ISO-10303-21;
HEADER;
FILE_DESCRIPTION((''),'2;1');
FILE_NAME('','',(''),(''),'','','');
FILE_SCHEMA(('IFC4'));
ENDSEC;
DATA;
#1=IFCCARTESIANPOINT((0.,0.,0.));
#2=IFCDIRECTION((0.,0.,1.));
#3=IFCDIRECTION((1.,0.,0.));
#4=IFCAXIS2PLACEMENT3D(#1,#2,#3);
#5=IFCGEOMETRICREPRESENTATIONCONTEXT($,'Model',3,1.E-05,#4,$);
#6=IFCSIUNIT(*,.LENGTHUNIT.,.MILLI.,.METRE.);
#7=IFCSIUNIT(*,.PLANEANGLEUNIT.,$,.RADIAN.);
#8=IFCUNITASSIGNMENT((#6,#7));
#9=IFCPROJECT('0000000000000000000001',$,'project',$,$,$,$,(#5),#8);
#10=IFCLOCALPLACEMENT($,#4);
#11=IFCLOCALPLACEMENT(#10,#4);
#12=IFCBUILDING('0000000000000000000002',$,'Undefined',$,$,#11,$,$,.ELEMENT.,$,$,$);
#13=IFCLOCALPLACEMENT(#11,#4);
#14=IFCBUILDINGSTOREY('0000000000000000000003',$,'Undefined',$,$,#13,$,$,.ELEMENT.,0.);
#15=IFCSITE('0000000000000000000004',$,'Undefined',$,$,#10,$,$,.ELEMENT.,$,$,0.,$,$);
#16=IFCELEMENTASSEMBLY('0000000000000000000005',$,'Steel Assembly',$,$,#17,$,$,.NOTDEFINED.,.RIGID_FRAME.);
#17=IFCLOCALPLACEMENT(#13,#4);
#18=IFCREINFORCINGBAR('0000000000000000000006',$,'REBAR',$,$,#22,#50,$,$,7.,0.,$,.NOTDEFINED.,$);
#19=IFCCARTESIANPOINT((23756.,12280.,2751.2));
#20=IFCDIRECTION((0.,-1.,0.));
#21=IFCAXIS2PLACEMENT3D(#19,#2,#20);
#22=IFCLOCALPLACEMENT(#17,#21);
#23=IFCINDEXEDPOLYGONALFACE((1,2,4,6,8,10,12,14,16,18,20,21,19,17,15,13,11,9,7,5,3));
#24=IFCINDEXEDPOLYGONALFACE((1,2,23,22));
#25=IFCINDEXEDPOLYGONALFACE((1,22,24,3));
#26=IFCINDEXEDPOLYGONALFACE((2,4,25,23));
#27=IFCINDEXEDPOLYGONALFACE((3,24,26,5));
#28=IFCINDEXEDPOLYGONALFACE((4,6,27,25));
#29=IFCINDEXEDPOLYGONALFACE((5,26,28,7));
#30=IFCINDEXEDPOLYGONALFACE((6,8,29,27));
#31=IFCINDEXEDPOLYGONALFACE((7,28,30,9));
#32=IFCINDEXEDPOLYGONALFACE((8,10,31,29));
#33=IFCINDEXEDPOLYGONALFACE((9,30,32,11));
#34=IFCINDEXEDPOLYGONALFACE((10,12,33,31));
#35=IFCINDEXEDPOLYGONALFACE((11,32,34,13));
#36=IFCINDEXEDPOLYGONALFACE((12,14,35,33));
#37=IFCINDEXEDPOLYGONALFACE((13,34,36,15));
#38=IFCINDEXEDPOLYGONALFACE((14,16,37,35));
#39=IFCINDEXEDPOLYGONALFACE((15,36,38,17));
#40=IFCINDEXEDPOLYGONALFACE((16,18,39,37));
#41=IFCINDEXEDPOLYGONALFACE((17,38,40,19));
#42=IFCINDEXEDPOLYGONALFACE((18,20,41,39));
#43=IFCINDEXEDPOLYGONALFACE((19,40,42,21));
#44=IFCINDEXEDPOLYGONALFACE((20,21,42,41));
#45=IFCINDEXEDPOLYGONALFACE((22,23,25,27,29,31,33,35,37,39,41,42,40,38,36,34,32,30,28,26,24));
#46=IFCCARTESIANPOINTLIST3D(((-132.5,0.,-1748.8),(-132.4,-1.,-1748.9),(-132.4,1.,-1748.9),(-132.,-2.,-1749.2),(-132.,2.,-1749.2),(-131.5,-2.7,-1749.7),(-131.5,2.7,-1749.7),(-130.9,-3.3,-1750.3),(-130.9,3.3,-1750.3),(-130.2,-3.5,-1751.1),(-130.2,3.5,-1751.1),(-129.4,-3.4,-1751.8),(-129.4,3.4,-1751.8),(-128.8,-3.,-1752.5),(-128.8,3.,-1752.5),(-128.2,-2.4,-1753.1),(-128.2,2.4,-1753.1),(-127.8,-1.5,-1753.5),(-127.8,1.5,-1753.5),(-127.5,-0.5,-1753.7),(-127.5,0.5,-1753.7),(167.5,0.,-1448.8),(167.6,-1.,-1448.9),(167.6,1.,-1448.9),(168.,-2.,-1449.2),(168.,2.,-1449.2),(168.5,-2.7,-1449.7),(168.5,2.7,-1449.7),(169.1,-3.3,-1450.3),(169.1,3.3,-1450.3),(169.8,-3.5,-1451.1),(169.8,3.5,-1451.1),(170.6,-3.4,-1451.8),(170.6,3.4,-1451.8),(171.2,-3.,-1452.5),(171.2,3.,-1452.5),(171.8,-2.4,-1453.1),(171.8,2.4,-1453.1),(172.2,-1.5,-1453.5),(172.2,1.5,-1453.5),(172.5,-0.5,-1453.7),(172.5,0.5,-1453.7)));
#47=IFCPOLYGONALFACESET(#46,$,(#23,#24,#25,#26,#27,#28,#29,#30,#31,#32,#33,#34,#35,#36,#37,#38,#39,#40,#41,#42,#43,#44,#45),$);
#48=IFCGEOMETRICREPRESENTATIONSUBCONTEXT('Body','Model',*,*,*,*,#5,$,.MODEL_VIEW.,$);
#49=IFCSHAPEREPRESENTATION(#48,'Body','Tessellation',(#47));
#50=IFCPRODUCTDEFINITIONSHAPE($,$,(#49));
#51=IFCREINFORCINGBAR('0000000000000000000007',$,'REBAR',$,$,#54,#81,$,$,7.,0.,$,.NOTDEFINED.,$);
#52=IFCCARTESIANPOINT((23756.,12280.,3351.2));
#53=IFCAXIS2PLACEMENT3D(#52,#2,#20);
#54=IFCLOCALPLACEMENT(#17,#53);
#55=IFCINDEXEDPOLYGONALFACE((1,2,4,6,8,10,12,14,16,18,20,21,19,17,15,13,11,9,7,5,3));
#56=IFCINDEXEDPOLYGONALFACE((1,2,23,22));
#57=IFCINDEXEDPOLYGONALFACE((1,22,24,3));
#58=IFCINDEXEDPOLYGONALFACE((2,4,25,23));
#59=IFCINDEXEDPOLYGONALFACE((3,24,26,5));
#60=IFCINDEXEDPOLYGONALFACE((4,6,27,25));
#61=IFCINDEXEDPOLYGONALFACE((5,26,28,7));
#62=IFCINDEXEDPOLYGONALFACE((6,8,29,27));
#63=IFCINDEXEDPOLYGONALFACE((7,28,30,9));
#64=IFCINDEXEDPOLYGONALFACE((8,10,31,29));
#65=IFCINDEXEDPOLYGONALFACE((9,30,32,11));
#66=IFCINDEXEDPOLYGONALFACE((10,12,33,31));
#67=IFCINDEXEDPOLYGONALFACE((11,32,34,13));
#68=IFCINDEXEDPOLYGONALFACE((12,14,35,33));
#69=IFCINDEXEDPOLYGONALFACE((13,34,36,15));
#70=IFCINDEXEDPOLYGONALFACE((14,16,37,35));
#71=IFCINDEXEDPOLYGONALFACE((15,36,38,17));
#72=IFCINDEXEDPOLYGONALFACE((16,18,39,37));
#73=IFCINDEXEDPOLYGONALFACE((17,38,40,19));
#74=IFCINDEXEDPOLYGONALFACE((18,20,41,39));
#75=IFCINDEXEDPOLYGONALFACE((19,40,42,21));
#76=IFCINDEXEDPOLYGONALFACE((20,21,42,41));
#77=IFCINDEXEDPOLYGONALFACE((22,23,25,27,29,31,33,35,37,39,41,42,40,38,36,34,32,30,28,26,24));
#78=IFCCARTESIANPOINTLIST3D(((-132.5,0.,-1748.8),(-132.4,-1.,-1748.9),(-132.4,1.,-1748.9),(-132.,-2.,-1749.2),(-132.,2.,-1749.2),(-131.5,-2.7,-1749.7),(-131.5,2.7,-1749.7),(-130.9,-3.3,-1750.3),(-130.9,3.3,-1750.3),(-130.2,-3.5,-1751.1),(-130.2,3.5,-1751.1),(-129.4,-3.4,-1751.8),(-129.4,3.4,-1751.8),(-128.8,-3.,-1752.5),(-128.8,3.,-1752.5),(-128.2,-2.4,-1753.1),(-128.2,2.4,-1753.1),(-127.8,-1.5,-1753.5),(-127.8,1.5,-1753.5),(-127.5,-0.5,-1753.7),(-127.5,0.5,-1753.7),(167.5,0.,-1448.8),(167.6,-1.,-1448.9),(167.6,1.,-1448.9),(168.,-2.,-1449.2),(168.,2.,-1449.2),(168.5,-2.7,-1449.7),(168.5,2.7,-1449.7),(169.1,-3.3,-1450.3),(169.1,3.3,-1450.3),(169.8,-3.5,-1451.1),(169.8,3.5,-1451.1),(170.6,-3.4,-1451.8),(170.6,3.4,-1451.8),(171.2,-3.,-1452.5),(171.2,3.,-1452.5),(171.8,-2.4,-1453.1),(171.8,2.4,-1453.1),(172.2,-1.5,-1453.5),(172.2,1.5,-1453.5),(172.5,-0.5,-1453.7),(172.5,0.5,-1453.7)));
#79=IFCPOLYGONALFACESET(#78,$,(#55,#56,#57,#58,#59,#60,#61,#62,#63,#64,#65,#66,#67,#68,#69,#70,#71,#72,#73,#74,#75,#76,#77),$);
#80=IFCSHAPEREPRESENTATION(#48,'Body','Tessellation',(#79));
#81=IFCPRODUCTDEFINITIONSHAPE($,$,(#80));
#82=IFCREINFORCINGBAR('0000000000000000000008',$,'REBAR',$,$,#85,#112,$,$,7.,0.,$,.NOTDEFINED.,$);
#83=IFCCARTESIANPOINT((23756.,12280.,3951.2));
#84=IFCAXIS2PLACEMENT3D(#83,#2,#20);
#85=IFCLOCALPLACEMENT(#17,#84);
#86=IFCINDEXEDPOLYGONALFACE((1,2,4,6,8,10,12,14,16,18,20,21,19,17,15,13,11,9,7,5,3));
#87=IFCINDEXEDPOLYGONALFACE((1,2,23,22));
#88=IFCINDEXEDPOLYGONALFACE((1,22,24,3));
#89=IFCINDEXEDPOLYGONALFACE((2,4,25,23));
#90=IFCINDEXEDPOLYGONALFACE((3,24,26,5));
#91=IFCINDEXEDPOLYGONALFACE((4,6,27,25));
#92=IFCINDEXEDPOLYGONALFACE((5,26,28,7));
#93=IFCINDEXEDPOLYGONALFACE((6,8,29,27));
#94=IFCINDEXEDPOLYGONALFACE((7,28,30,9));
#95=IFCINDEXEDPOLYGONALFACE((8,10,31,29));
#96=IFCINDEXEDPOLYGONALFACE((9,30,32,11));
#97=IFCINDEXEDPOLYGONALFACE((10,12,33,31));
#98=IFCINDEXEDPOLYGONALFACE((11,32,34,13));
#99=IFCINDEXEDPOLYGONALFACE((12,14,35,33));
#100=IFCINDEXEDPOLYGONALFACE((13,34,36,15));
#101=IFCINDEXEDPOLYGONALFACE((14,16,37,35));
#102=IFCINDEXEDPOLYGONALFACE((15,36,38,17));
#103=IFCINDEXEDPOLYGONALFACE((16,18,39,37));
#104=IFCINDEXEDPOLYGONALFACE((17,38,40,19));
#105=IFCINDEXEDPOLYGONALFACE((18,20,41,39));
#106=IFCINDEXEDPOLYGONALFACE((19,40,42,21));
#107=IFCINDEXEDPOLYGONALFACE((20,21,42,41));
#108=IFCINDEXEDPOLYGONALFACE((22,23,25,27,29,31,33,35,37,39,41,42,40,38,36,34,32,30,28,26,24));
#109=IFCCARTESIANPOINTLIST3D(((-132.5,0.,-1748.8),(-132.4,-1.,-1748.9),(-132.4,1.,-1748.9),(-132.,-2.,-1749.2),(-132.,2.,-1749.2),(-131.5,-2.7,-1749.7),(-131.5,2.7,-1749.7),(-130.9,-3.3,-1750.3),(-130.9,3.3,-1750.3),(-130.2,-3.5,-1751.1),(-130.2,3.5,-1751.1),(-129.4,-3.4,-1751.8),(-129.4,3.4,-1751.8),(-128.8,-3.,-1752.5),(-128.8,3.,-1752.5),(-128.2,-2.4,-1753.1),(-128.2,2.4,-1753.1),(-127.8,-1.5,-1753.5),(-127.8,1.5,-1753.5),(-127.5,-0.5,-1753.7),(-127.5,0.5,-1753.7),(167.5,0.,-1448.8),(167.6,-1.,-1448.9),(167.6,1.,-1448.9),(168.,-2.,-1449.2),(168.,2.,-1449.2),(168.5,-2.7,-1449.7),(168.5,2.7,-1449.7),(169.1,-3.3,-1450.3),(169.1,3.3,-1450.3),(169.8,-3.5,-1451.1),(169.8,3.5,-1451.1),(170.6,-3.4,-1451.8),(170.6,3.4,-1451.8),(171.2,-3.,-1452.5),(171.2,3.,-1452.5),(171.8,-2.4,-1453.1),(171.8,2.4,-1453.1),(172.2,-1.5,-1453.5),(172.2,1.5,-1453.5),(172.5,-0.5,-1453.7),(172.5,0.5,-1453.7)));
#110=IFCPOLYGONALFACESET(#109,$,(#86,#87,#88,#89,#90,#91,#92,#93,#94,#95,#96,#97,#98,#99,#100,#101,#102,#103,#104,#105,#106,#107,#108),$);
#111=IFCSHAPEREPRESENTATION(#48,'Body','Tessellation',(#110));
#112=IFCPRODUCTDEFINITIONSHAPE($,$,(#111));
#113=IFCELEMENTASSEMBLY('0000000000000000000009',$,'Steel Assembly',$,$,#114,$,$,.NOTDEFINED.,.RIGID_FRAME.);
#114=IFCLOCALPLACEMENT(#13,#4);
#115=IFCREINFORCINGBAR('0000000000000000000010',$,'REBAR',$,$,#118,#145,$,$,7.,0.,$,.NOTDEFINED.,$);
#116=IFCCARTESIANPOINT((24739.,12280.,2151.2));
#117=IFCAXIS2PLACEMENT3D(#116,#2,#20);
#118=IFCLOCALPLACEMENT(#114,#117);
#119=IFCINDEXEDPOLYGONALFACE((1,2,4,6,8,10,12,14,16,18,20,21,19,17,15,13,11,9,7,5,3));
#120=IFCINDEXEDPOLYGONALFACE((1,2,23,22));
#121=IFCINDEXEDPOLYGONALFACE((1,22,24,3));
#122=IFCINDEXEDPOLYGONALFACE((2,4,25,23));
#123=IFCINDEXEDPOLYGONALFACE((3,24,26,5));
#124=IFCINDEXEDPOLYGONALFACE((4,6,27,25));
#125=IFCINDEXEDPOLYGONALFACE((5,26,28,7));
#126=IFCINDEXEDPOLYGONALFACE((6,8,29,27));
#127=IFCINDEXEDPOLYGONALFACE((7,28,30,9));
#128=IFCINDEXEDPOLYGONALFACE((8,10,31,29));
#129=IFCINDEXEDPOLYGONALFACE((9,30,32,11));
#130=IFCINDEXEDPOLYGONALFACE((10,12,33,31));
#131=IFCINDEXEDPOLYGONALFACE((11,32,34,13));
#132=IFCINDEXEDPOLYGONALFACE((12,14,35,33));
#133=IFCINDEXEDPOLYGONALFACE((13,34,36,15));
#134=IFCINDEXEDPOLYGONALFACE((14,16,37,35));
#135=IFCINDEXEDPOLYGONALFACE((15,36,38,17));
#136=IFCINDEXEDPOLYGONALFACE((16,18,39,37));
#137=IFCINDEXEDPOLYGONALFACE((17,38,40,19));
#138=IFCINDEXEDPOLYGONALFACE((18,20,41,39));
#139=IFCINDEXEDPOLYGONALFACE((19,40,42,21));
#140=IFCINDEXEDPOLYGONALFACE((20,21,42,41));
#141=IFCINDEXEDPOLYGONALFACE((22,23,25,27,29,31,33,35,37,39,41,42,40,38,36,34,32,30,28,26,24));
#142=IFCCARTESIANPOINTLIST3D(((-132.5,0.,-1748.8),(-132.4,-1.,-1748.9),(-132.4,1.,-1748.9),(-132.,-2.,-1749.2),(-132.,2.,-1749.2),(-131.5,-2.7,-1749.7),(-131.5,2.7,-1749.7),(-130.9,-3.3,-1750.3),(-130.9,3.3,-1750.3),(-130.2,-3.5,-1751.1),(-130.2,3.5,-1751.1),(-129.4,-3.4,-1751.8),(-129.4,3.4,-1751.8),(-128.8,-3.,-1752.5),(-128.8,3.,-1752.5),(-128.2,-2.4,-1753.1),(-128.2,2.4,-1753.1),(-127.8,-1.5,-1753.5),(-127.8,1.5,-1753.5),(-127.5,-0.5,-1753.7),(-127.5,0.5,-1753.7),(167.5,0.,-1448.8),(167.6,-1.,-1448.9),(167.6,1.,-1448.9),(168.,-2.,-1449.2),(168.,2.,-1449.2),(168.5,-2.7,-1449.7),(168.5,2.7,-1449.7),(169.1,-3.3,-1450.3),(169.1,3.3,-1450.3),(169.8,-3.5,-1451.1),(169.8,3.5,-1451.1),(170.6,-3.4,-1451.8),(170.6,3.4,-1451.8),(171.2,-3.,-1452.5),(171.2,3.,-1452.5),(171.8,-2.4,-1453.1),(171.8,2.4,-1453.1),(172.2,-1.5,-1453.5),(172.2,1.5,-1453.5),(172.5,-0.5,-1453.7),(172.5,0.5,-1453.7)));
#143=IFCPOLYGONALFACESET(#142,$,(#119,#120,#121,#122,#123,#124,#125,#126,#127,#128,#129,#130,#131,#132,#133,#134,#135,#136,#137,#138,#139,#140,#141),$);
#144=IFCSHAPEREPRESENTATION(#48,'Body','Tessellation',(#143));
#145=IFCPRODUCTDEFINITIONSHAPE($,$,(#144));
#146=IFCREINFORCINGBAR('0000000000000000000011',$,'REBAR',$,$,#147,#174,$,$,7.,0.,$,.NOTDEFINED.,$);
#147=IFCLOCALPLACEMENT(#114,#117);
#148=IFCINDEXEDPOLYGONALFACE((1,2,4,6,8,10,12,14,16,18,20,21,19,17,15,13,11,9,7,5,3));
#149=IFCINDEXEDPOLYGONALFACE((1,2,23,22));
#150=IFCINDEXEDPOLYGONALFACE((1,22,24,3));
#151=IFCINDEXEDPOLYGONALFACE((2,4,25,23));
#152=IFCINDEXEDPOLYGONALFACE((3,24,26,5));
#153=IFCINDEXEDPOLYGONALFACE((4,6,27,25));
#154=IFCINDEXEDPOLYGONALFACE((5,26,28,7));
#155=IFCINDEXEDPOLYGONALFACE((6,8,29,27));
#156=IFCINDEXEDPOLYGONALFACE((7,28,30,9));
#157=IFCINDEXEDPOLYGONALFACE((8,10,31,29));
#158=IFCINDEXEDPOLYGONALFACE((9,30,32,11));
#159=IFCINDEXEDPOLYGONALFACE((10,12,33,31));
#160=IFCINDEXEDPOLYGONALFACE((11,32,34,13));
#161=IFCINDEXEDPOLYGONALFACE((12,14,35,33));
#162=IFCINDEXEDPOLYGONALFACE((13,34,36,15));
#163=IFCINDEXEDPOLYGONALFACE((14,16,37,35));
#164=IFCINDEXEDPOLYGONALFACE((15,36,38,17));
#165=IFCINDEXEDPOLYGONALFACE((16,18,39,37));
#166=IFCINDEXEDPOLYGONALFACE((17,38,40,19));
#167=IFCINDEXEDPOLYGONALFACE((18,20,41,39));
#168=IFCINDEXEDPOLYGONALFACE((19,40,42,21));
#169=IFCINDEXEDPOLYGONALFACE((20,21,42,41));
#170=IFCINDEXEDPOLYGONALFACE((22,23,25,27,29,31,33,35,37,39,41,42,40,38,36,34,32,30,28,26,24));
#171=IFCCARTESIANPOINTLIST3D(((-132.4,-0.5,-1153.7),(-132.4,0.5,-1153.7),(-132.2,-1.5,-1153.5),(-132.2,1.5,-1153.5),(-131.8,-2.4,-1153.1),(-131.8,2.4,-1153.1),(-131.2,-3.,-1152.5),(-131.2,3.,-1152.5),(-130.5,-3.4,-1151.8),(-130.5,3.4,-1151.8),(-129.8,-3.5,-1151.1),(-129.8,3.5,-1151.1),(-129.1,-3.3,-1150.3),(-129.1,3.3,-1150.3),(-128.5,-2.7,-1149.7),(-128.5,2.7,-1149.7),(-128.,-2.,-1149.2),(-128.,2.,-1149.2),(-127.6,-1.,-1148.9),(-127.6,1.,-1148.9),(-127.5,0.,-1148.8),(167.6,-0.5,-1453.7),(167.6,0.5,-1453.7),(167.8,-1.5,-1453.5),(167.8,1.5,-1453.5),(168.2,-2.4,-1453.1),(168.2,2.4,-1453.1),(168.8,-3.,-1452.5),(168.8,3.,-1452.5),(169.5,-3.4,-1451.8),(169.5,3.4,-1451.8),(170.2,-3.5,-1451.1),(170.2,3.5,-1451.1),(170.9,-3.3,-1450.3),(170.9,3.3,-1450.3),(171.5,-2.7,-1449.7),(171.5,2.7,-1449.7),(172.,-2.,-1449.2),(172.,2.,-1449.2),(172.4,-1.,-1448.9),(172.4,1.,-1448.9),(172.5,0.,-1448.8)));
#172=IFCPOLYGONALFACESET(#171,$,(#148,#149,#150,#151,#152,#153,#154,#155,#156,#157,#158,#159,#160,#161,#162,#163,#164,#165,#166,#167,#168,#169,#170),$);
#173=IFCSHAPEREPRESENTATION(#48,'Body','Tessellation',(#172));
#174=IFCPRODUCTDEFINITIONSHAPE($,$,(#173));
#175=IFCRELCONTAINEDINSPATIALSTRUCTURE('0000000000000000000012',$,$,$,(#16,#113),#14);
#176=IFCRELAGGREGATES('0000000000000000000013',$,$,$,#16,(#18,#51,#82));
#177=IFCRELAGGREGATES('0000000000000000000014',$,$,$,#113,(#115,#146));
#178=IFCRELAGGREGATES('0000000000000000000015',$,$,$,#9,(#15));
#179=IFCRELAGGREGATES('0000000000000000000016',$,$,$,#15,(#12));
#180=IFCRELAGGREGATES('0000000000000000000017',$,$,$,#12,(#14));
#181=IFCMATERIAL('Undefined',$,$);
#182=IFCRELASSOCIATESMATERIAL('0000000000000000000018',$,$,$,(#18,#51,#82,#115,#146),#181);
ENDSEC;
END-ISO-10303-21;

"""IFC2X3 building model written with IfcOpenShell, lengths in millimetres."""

from ifc_helpers import new_model, entity, si_unit, frame, origin_with_axes, place, context, subcontext, project, spatial, source, transform, mapped, material, element, aggregate, save


model = new_model("IFC2X3")

# Units and contexts
model_context = context("Model", 3, precision=1e-05, world=origin_with_axes())
body_context = subcontext(model_context, "Body", "Model", "MODEL_VIEW")
ifc_project = project(units=[si_unit("LENGTHUNIT", "METRE", prefix="MILLI"), si_unit("PLANEANGLEUNIT", "RADIAN")], contexts=[model_context])

# Site, building, storey
site_placement = place(None, origin_with_axes())
site = spatial("IfcSite", under=ifc_project, at=site_placement, Name="Undefined", CompositionType="ELEMENT", RefElevation=0.0)
building_placement = place(site_placement, origin_with_axes())
building = spatial("IfcBuilding", under=site, at=building_placement, Name="Undefined", CompositionType="ELEMENT")
storey_placement = place(building_placement, origin_with_axes())
storey = spatial("IfcBuildingStorey", under=building, at=storey_placement, Name="Undefined", CompositionType="ELEMENT", Elevation=0.0)

# Shared definitions
ifc_material_1 = material(Name="Undefined")

# Element assemblies, reinforcing bars
assembly_1_placement = place(storey_placement, origin_with_axes())
assembly_1 = element("IfcElementAssembly", 1, at=assembly_1_placement, inside=storey, Name="Steel Assembly", AssemblyPlace="NOTDEFINED", PredefinedType="RIGID_FRAME")
shared_shape_1 = source(origin_with_axes(), body_context, "Body", "AdvancedSweptSolid", [
    entity("IfcSweptDiskSolid", entity("IfcTrimmedCurve", entity("IfcLine", entity("IfcCartesianPoint", [0.0, 0.0, 0.0]), entity("IfcVector", entity("IfcDirection", [0.707107, 0.0, 0.707107]), 1.0)), [entity("IfcParameterValue", 0.0)], [entity("IfcParameterValue", 424.264069)], True, "PARAMETER"), 3.5, None, 0.0, 424.3),
])
reinforcing_bar_1_placement = place(assembly_1_placement, frame((23756.0, 12280.0, 2751.2), z_axis=(0.0, 0.0, 1.0), x_axis=(0.0, -1.0, 0.0)))
reinforcing_bar_1 = element("IfcReinforcingBar", 2, at=reinforcing_bar_1_placement, material=ifc_material_1, Name="REBAR", BarRole="NOTDEFINED", CrossSectionArea=0.0, NominalDiameter=7.0, context=body_context, shape_type="MappedRepresentation", body=[
    mapped(shared_shape_1, transform((-130.0, 0.0, -1751.2))),
])
shared_shape_2 = source(origin_with_axes(), body_context, "Body", "AdvancedSweptSolid", [
    entity("IfcSweptDiskSolid", entity("IfcTrimmedCurve", entity("IfcLine", entity("IfcCartesianPoint", [0.0, 0.0, 0.0]), entity("IfcVector", entity("IfcDirection", [0.707107, 0.0, 0.707107]), 1.0)), [entity("IfcParameterValue", 0.0)], [entity("IfcParameterValue", 424.264069)], True, "PARAMETER"), 3.5, None, 0.0, 424.3),
])
reinforcing_bar_2_placement = place(assembly_1_placement, frame((23756.0, 12280.0, 3351.2), z_axis=(0.0, 0.0, 1.0), x_axis=(0.0, -1.0, 0.0)))
reinforcing_bar_2 = element("IfcReinforcingBar", 3, at=reinforcing_bar_2_placement, material=ifc_material_1, Name="REBAR", BarRole="NOTDEFINED", CrossSectionArea=0.0, NominalDiameter=7.0, context=body_context, shape_type="MappedRepresentation", body=[
    mapped(shared_shape_2, transform((-130.0, 0.0, -1751.2))),
])
shared_shape_3 = source(origin_with_axes(), body_context, "Body", "AdvancedSweptSolid", [
    entity("IfcSweptDiskSolid", entity("IfcTrimmedCurve", entity("IfcLine", entity("IfcCartesianPoint", [0.0, 0.0, 0.0]), entity("IfcVector", entity("IfcDirection", [0.707107, 0.0, 0.707107]), 1.0)), [entity("IfcParameterValue", 0.0)], [entity("IfcParameterValue", 424.264069)], True, "PARAMETER"), 3.5, None, 0.0, 424.3),
])
reinforcing_bar_3_placement = place(assembly_1_placement, frame((23756.0, 12280.0, 3951.2), z_axis=(0.0, 0.0, 1.0), x_axis=(0.0, -1.0, 0.0)))
reinforcing_bar_3 = element("IfcReinforcingBar", 4, at=reinforcing_bar_3_placement, material=ifc_material_1, Name="REBAR", BarRole="NOTDEFINED", CrossSectionArea=0.0, NominalDiameter=7.0, context=body_context, shape_type="MappedRepresentation", body=[
    mapped(shared_shape_3, transform((-130.0, 0.0, -1751.2))),
])
aggregate(assembly_1, [reinforcing_bar_1, reinforcing_bar_2, reinforcing_bar_3])
assembly_2_placement = place(storey_placement, origin_with_axes())
assembly_2 = element("IfcElementAssembly", 5, at=assembly_2_placement, inside=storey, Name="Steel Assembly", AssemblyPlace="NOTDEFINED", PredefinedType="RIGID_FRAME")
shared_shape_4 = source(origin_with_axes(), body_context, "Body", "AdvancedSweptSolid", [
    entity("IfcSweptDiskSolid", entity("IfcTrimmedCurve", entity("IfcLine", entity("IfcCartesianPoint", [0.0, 0.0, 0.0]), entity("IfcVector", entity("IfcDirection", [0.707107, 0.0, 0.707107]), 1.0)), [entity("IfcParameterValue", 0.0)], [entity("IfcParameterValue", 424.264069)], True, "PARAMETER"), 3.5, None, 0.0, 424.3),
])
reinforcing_bar_4_placement = place(assembly_2_placement, frame((24739.0, 12280.0, 2151.2), z_axis=(0.0, 0.0, 1.0), x_axis=(0.0, -1.0, 0.0)))
reinforcing_bar_4 = element("IfcReinforcingBar", 6, at=reinforcing_bar_4_placement, material=ifc_material_1, Name="REBAR", BarRole="NOTDEFINED", CrossSectionArea=0.0, NominalDiameter=7.0, context=body_context, shape_type="MappedRepresentation", body=[
    mapped(shared_shape_4, transform((-130.0, 0.0, -1751.2))),
])
shared_shape_5 = source(origin_with_axes(), body_context, "Body", "AdvancedSweptSolid", [
    entity("IfcSweptDiskSolid", entity("IfcTrimmedCurve", entity("IfcLine", entity("IfcCartesianPoint", [0.0, 0.0, 0.0]), entity("IfcVector", entity("IfcDirection", [0.707107, 0.0, -0.707107]), 1.0)), [entity("IfcParameterValue", 0.0)], [entity("IfcParameterValue", 424.264069)], True, "PARAMETER"), 3.5, None, 0.0, 424.3),
])
reinforcing_bar_5_placement = place(assembly_2_placement, frame((24739.0, 12280.0, 2151.2), z_axis=(0.0, 0.0, 1.0), x_axis=(0.0, -1.0, 0.0)))
reinforcing_bar_5 = element("IfcReinforcingBar", 7, at=reinforcing_bar_5_placement, material=ifc_material_1, Name="REBAR", BarRole="NOTDEFINED", CrossSectionArea=0.0, NominalDiameter=7.0, context=body_context, shape_type="MappedRepresentation", body=[
    mapped(shared_shape_5, transform((-130.0, 0.0, -1151.2))),
])
aggregate(assembly_2, [reinforcing_bar_4, reinforcing_bar_5])

save(model, "model.ifc")
